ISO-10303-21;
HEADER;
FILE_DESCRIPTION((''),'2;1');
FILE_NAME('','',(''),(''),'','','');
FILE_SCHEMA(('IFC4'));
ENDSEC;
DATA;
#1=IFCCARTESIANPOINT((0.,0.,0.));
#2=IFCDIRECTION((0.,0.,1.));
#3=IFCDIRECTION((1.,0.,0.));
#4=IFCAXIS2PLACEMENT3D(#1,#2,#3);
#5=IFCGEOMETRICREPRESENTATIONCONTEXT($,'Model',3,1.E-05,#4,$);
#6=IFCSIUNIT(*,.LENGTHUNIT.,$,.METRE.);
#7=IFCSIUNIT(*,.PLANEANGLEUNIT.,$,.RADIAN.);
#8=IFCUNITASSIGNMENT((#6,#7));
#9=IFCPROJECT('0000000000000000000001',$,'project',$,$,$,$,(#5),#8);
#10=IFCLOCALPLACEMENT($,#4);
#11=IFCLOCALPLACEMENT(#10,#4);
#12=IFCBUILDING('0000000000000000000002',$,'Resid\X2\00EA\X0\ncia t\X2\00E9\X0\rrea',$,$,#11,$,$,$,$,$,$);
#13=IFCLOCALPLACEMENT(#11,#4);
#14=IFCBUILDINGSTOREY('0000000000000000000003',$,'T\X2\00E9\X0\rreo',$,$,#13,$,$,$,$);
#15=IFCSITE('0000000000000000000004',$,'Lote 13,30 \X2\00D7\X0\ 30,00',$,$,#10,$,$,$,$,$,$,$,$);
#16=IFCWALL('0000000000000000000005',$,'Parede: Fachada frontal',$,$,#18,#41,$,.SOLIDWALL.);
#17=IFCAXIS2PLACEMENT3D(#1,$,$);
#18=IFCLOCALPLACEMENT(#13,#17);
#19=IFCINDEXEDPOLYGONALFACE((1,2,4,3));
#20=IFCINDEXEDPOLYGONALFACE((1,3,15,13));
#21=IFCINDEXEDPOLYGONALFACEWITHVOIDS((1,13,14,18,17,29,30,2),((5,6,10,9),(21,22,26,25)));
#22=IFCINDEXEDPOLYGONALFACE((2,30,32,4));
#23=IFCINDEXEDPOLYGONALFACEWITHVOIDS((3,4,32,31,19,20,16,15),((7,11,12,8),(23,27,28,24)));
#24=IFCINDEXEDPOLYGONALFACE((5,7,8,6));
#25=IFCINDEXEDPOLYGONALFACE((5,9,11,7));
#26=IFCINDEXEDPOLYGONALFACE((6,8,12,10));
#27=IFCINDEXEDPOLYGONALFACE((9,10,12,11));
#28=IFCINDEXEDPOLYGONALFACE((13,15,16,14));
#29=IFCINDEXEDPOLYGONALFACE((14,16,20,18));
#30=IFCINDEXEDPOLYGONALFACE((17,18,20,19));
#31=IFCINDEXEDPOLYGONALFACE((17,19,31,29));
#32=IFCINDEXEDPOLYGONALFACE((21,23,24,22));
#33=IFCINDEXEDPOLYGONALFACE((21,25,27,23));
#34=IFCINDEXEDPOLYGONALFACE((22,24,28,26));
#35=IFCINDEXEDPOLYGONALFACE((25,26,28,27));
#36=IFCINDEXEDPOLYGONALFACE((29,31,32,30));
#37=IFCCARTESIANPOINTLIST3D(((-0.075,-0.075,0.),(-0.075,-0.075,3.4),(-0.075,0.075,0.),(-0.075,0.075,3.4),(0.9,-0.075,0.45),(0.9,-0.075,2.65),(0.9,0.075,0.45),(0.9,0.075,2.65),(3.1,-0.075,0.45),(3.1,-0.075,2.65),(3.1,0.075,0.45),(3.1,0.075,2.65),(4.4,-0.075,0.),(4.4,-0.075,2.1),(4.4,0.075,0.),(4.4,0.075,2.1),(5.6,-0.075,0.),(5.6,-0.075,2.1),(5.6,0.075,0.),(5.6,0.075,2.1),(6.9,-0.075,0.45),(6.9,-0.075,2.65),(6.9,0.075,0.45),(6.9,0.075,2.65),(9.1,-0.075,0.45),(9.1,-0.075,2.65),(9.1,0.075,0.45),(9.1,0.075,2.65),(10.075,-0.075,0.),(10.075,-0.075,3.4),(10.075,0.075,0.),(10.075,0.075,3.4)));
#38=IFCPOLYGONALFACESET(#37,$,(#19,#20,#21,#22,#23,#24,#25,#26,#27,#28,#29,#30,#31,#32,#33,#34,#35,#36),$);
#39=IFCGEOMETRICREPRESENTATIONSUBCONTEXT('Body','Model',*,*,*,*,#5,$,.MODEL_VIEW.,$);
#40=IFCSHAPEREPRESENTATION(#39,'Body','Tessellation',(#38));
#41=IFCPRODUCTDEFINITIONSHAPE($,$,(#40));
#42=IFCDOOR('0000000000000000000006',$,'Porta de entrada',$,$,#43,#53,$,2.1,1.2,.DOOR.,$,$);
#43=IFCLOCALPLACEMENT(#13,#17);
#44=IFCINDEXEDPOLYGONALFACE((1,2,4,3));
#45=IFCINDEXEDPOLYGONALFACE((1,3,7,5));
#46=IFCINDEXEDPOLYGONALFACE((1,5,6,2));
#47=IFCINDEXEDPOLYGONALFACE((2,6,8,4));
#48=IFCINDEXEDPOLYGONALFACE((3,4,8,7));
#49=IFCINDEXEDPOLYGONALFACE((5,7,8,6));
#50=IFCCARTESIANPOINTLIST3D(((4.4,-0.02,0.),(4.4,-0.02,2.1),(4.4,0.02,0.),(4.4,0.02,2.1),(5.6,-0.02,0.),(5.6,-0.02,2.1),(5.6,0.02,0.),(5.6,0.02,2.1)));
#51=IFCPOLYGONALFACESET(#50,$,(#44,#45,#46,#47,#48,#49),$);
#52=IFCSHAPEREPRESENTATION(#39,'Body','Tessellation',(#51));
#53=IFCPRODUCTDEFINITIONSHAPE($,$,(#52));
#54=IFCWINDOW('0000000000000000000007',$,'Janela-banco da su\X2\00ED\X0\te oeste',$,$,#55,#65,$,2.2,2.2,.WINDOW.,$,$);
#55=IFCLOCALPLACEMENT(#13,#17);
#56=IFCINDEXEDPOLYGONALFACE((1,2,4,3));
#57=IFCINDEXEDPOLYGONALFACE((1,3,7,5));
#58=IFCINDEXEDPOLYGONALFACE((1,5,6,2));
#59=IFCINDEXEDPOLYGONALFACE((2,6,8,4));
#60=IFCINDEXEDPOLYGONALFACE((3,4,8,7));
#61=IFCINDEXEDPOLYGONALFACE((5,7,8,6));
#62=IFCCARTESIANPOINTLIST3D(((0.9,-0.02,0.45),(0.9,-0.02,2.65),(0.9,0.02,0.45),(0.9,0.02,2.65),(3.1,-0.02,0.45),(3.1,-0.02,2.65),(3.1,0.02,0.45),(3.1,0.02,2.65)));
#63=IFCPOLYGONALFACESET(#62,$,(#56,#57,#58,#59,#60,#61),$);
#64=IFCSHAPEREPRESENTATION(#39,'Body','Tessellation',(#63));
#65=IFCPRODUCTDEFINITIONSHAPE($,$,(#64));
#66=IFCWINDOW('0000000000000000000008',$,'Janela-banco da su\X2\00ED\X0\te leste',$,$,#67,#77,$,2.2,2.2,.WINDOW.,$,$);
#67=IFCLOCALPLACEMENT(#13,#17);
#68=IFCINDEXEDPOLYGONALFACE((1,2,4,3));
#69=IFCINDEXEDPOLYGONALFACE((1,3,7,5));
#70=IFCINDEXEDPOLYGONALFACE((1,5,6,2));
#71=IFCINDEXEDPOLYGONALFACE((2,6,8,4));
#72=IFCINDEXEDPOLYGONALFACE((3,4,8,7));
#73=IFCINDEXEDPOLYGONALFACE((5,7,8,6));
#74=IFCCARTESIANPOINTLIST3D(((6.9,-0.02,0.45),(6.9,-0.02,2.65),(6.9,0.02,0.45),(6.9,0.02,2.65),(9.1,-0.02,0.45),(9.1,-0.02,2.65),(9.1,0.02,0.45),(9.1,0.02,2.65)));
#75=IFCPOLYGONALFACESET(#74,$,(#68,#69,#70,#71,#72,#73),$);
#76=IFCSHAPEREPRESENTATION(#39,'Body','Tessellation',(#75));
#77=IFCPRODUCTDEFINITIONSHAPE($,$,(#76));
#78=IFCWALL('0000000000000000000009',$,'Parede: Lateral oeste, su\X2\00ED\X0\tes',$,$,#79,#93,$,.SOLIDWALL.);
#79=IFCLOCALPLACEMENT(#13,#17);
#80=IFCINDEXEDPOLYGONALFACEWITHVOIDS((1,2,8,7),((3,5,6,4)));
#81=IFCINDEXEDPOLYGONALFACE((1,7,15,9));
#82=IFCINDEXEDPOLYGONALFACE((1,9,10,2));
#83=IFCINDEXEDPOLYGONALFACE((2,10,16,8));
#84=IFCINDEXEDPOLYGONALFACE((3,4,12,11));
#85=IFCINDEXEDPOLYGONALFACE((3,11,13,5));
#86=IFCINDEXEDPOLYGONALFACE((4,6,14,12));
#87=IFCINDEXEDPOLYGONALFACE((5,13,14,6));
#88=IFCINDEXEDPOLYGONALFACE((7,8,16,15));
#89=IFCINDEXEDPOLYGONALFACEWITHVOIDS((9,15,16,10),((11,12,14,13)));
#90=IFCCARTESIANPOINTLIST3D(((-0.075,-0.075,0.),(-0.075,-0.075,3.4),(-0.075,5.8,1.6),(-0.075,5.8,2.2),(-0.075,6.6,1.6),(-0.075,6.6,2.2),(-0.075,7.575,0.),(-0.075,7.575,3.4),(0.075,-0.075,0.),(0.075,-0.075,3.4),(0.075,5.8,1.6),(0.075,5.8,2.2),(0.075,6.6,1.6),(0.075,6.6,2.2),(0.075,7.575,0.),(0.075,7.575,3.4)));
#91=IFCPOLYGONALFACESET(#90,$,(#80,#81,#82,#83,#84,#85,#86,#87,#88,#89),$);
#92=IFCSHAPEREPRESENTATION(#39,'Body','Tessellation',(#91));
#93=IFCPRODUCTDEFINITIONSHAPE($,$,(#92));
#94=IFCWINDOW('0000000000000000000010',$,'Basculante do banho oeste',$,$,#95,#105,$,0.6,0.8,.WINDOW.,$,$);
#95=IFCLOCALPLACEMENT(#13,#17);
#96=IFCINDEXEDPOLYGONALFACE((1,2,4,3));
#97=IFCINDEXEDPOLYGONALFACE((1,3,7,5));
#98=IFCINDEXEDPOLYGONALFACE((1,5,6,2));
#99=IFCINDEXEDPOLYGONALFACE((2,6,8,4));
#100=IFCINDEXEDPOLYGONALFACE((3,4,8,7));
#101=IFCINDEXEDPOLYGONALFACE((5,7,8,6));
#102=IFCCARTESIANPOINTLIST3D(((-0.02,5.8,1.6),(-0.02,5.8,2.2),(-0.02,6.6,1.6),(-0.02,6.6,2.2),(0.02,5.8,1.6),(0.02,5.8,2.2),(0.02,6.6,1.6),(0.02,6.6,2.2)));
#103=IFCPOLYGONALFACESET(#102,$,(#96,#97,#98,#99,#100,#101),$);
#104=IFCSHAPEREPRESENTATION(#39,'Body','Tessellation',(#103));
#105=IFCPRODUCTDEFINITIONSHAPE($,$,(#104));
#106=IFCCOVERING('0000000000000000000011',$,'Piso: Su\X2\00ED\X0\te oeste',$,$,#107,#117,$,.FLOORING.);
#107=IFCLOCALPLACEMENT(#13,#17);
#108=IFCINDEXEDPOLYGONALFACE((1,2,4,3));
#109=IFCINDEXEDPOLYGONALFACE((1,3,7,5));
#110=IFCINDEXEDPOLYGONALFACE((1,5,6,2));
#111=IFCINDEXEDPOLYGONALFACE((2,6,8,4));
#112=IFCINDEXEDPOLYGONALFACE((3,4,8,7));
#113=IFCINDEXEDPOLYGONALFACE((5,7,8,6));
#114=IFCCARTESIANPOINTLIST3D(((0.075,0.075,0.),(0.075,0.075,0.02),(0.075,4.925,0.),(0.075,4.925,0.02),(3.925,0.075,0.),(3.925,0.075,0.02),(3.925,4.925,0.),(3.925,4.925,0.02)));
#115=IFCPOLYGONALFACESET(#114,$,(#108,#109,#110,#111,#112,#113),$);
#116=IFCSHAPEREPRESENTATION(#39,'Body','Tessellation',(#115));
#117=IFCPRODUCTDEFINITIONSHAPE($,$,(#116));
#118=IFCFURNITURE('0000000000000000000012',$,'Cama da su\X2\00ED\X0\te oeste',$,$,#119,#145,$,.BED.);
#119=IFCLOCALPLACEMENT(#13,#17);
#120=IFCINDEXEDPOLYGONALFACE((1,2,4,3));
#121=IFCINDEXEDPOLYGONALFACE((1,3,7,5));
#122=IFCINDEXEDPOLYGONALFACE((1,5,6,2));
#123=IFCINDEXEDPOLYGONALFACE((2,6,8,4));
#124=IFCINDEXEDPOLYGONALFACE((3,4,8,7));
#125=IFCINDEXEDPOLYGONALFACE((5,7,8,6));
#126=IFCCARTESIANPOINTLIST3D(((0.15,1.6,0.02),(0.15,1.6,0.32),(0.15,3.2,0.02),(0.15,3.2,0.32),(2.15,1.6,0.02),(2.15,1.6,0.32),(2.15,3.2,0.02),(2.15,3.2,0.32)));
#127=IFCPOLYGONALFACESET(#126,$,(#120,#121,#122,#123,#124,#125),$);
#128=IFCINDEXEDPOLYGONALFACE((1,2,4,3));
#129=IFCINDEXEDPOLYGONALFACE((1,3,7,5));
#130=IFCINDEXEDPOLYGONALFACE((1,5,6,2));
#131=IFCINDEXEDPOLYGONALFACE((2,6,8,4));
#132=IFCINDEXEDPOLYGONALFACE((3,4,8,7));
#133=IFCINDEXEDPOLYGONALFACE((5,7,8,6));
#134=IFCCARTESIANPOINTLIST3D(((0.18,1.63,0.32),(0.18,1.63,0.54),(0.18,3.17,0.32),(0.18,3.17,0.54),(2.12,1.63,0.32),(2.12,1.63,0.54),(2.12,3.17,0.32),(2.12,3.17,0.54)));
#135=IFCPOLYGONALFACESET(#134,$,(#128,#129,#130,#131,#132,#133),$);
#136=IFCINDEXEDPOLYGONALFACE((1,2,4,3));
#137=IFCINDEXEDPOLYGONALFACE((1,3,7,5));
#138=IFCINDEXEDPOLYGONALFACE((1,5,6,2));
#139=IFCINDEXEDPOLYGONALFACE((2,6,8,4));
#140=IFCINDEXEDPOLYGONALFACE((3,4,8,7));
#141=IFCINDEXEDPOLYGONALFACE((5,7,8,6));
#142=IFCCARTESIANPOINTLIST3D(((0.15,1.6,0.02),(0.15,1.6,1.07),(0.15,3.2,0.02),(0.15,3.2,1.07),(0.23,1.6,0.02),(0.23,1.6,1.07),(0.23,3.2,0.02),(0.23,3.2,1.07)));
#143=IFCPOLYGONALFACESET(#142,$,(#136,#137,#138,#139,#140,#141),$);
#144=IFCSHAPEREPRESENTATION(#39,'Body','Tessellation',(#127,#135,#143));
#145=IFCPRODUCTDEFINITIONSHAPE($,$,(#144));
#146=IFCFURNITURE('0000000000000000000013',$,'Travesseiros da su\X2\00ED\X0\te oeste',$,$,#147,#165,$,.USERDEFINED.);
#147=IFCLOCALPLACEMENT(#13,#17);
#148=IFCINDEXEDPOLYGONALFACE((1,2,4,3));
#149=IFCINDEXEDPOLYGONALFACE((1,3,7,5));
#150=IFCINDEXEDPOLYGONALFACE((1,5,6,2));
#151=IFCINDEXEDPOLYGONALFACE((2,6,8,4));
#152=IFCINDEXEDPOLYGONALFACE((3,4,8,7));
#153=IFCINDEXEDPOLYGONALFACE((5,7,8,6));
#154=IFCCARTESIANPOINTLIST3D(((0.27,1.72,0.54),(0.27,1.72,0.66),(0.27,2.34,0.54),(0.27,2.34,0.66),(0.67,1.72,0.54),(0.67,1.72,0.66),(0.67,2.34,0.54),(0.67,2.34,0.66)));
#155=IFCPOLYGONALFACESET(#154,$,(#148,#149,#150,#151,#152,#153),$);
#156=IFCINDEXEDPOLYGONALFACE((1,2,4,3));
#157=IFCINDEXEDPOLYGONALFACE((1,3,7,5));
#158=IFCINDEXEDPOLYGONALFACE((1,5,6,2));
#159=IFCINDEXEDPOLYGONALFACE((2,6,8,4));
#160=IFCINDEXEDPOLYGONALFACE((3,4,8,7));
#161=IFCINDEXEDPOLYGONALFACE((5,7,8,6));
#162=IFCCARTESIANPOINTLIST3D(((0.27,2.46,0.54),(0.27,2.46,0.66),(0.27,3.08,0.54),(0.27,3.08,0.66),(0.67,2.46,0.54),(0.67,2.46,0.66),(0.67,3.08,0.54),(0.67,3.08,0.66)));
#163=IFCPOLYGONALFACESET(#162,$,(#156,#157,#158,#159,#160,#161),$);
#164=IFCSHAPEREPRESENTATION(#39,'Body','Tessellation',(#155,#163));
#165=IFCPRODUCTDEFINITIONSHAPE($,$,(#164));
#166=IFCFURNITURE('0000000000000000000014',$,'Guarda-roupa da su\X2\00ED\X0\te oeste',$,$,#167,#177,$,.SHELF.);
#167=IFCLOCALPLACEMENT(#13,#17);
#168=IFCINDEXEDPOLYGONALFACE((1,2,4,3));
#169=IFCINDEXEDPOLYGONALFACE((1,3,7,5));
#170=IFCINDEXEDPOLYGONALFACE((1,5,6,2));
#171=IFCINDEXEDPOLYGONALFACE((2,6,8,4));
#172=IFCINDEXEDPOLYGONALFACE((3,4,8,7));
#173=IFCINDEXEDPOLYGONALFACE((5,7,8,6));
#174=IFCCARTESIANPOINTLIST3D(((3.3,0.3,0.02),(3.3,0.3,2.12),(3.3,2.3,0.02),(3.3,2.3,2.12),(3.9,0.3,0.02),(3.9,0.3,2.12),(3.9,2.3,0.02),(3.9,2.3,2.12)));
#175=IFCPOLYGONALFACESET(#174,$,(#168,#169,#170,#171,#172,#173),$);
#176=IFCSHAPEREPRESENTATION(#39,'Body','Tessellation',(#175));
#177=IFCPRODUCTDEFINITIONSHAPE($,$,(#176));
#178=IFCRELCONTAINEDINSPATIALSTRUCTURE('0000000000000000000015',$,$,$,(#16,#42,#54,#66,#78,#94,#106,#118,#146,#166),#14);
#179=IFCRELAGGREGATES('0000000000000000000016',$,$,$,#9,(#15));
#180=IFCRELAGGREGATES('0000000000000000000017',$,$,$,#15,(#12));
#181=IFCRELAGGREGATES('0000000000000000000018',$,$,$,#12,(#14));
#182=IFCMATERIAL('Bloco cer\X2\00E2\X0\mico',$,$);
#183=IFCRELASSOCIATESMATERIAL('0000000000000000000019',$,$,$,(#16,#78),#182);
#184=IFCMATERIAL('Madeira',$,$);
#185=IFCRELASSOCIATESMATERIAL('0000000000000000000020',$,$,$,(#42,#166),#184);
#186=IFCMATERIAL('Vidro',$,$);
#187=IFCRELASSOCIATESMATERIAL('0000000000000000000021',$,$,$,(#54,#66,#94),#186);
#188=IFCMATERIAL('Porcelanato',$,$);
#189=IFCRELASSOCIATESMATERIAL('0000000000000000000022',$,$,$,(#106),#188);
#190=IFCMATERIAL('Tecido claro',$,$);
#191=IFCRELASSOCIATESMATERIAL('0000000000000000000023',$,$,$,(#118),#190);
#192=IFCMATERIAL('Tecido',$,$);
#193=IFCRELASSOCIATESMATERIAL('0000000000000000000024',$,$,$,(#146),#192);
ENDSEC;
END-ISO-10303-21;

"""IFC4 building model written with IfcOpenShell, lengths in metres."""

from ifc_helpers import new_model, si_unit, frame, origin_with_axes, place, context, subcontext, project, spatial, line, indexed_curve, outline, extrude, material, element, fill, save


model = new_model("IFC4")

# Units and contexts
model_context = context("Model", 3, precision=1e-05, world=origin_with_axes())
body_context = subcontext(model_context, "Body", "Model", "MODEL_VIEW")
ifc_project = project(units=[si_unit("LENGTHUNIT", "METRE"), si_unit("PLANEANGLEUNIT", "RADIAN")], contexts=[model_context])

# Site, building, storey
site_placement = place(None, origin_with_axes())
site = spatial("IfcSite", under=ifc_project, at=site_placement, Name="Lote 13,30 × 30,00")
building_placement = place(site_placement, origin_with_axes())
building = spatial("IfcBuilding", under=site, at=building_placement, Name="Residência térrea")
storey_placement = place(building_placement, origin_with_axes())
storey = spatial("IfcBuildingStorey", under=building, at=storey_placement, Name="Térreo")

# Shared definitions
ifc_material_1 = material(Name="Concreto armado")

# Wall, openings, door, windows
ifc_material_2 = material(Name="Bloco cerâmico")
wall_1_placement = place(storey_placement, frame((-0.075, -0.075, 0.0), z_axis=(0.0, 0.0, 1.0), x_axis=(1.0, 0.0, 0.0)))
wall_1 = element("IfcWall", 1, at=wall_1_placement, inside=storey, material=ifc_material_2, Name="Parede: Fachada frontal", PredefinedType="SOLIDWALL", context=body_context, shape_type="SweptSolid", body=[
    extrude(outline(indexed_curve([(0.0, 0.0), (10.15, 0.0), (10.15, 0.15), (0.0, 0.15)], segments=[line(1, 2, 3, 4, 1)])), origin_with_axes(), (0.0, 0.0, 1.0), 3.4),
])
opening_1_placement = place(wall_1_placement, frame((4.475, -0.05, 0.0), z_axis=(0.0, 0.0, 1.0), x_axis=(1.0, 0.0, 0.0)))
opening_1 = element("IfcOpeningElement", 2, at=opening_1_placement, cuts=wall_1, material=ifc_material_1, PredefinedType="OPENING", context=body_context, shape_type="SweptSolid", body=[
    extrude(outline(indexed_curve([(0.0, 0.0), (1.2, 0.0), (1.2, 0.25), (0.0, 0.25)], segments=[line(1, 2, 3, 4, 1)])), origin_with_axes(), (0.0, 0.0, 1.0), 2.1),
])
opening_2_placement = place(wall_1_placement, frame((0.975, -0.05, 0.45), z_axis=(0.0, 0.0, 1.0), x_axis=(1.0, 0.0, 0.0)))
opening_2 = element("IfcOpeningElement", 3, at=opening_2_placement, cuts=wall_1, material=ifc_material_1, PredefinedType="OPENING", context=body_context, shape_type="SweptSolid", body=[
    extrude(outline(indexed_curve([(0.0, 0.0), (2.2, 0.0), (2.2, 0.25), (0.0, 0.25)], segments=[line(1, 2, 3, 4, 1)])), origin_with_axes(), (0.0, 0.0, 1.0), 2.2),
])
opening_3_placement = place(wall_1_placement, frame((6.975, -0.05, 0.45), z_axis=(0.0, 0.0, 1.0), x_axis=(1.0, 0.0, 0.0)))
opening_3 = element("IfcOpeningElement", 4, at=opening_3_placement, cuts=wall_1, material=ifc_material_1, PredefinedType="OPENING", context=body_context, shape_type="SweptSolid", body=[
    extrude(outline(indexed_curve([(0.0, 0.0), (2.2, 0.0), (2.2, 0.25), (0.0, 0.25)], segments=[line(1, 2, 3, 4, 1)])), origin_with_axes(), (0.0, 0.0, 1.0), 2.2),
])
ifc_material_3 = material(Name="Madeira")
door_placement = place(storey_placement, frame((4.4, -0.02, 0.0), z_axis=(0.0, 0.0, 1.0), x_axis=(1.0, 0.0, 0.0)))
door = element("IfcDoor", 5, at=door_placement, inside=storey, material=ifc_material_3, Name="Porta de entrada", OverallHeight=2.1, OverallWidth=1.2, PredefinedType="DOOR", context=body_context, shape_type="SweptSolid", body=[
    extrude(outline(indexed_curve([(0.0, 0.0), (1.2, 0.0), (1.2, 0.04), (0.0, 0.04)], segments=[line(1, 2, 3, 4, 1)])), origin_with_axes(), (0.0, 0.0, 1.0), 2.1),
])
fill(opening_1, door)
ifc_material_4 = material(Name="Vidro")
window_1_placement = place(storey_placement, frame((0.9, -0.02, 0.45), z_axis=(0.0, 0.0, 1.0), x_axis=(1.0, 0.0, 0.0)))
window_1 = element("IfcWindow", 6, at=window_1_placement, inside=storey, material=ifc_material_4, Name="Janela-banco da suíte oeste", OverallHeight=2.2, OverallWidth=2.2, PredefinedType="WINDOW", context=body_context, shape_type="SweptSolid", body=[
    extrude(outline(indexed_curve([(0.0, 0.0), (2.2, 0.0), (2.2, 0.04), (0.0, 0.04)], segments=[line(1, 2, 3, 4, 1)])), origin_with_axes(), (0.0, 0.0, 1.0), 2.2),
])
fill(opening_2, window_1)
window_2_placement = place(storey_placement, frame((6.9, -0.02, 0.45), z_axis=(0.0, 0.0, 1.0), x_axis=(1.0, 0.0, 0.0)))
window_2 = element("IfcWindow", 7, at=window_2_placement, inside=storey, material=ifc_material_4, Name="Janela-banco da suíte leste", OverallHeight=2.2, OverallWidth=2.2, PredefinedType="WINDOW", context=body_context, shape_type="SweptSolid", body=[
    extrude(outline(indexed_curve([(0.0, 0.0), (2.2, 0.0), (2.2, 0.04), (0.0, 0.04)], segments=[line(1, 2, 3, 4, 1)])), origin_with_axes(), (0.0, 0.0, 1.0), 2.2),
])
fill(opening_3, window_2)

# Wall, opening, window
wall_2_placement = place(storey_placement, frame((-0.075, -0.075, 0.0), z_axis=(0.0, 0.0, 1.0), x_axis=(1.0, 0.0, 0.0)))
wall_2 = element("IfcWall", 8, at=wall_2_placement, inside=storey, material=ifc_material_2, Name="Parede: Lateral oeste, suítes", PredefinedType="SOLIDWALL", context=body_context, shape_type="SweptSolid", body=[
    extrude(outline(indexed_curve([(0.0, 0.0), (0.15, 0.0), (0.15, 7.65), (0.0, 7.65)], segments=[line(1, 2, 3, 4, 1)])), origin_with_axes(), (0.0, 0.0, 1.0), 3.4),
])
opening_4_placement = place(wall_2_placement, frame((-0.05, 5.875, 1.6), z_axis=(0.0, 0.0, 1.0), x_axis=(1.0, 0.0, 0.0)))
opening_4 = element("IfcOpeningElement", 9, at=opening_4_placement, cuts=wall_2, material=ifc_material_1, PredefinedType="OPENING", context=body_context, shape_type="SweptSolid", body=[
    extrude(outline(indexed_curve([(0.0, 0.0), (0.25, 0.0), (0.25, 0.8), (0.0, 0.8)], segments=[line(1, 2, 3, 4, 1)])), origin_with_axes(), (0.0, 0.0, 1.0), 0.6),
])
window_3_placement = place(storey_placement, frame((-0.02, 5.8, 1.6), z_axis=(0.0, 0.0, 1.0), x_axis=(1.0, 0.0, 0.0)))
window_3 = element("IfcWindow", 10, at=window_3_placement, inside=storey, material=ifc_material_4, Name="Basculante do banho oeste", OverallHeight=0.6, OverallWidth=0.8, PredefinedType="WINDOW", context=body_context, shape_type="SweptSolid", body=[
    extrude(outline(indexed_curve([(0.0, 0.0), (0.04, 0.0), (0.04, 0.8), (0.0, 0.8)], segments=[line(1, 2, 3, 4, 1)])), origin_with_axes(), (0.0, 0.0, 1.0), 0.6),
])
fill(opening_4, window_3)

# Covering
ifc_material_5 = material(Name="Porcelanato")
covering_placement = place(storey_placement, frame((0.075, 0.075, 0.0), z_axis=(0.0, 0.0, 1.0), x_axis=(1.0, 0.0, 0.0)))
element("IfcCovering", 11, at=covering_placement, inside=storey, material=ifc_material_5, Name="Piso: Suíte oeste", PredefinedType="FLOORING", context=body_context, shape_type="SweptSolid", body=[
    extrude(outline(indexed_curve([(0.0, 0.0), (3.85, 0.0), (3.85, 4.85), (0.0, 4.85)], segments=[line(1, 2, 3, 4, 1)])), origin_with_axes(), (0.0, 0.0, 1.0), 0.02),
])

# Furniture
ifc_material_6 = material(Name="Tecido claro")
furniture_1_placement = place(storey_placement, frame((0.15, 1.6, 0.02), z_axis=(0.0, 0.0, 1.0), x_axis=(1.0, 0.0, 0.0)))
element("IfcFurniture", 12, at=furniture_1_placement, inside=storey, material=ifc_material_6, Name="Cama da suíte oeste", PredefinedType="BED", context=body_context, shape_type="SweptSolid", body=[
    extrude(outline(indexed_curve([(0.0, 0.0), (2.0, 0.0), (2.0, 1.6), (0.0, 1.6)], segments=[line(1, 2, 3, 4, 1)])), origin_with_axes(), (0.0, 0.0, 1.0), 0.3),
    extrude(outline(indexed_curve([(0.03, 0.03), (1.97, 0.03), (1.97, 1.57), (0.03, 1.57)], segments=[line(1, 2, 3, 4, 1)])), frame((0.0, 0.0, 0.3), z_axis=(0.0, 0.0, 1.0), x_axis=(1.0, 0.0, 0.0)), (0.0, 0.0, 1.0), 0.22),
    extrude(outline(indexed_curve([(0.0, 0.0), (0.08, 0.0), (0.08, 1.6), (0.0, 1.6)], segments=[line(1, 2, 3, 4, 1)])), origin_with_axes(), (0.0, 0.0, 1.0), 1.05),
])
ifc_material_7 = material(Name="Tecido")
furniture_2_placement = place(storey_placement, frame((0.27, 1.72, 0.54), z_axis=(0.0, 0.0, 1.0), x_axis=(1.0, 0.0, 0.0)))
element("IfcFurniture", 13, at=furniture_2_placement, inside=storey, material=ifc_material_7, Name="Travesseiros da suíte oeste", PredefinedType="USERDEFINED", context=body_context, shape_type="SweptSolid", body=[
    extrude(outline(indexed_curve([(0.0, 0.0), (0.4, 0.0), (0.4, 0.62), (0.0, 0.62)], segments=[line(1, 2, 3, 4, 1)])), origin_with_axes(), (0.0, 0.0, 1.0), 0.12),
    extrude(outline(indexed_curve([(0.0, 0.74), (0.4, 0.74), (0.4, 1.36), (0.0, 1.36)], segments=[line(1, 2, 3, 4, 1)])), origin_with_axes(), (0.0, 0.0, 1.0), 0.12),
])
furniture_3_placement = place(storey_placement, frame((3.3, 0.3, 0.02), z_axis=(0.0, 0.0, 1.0), x_axis=(1.0, 0.0, 0.0)))
element("IfcFurniture", 14, at=furniture_3_placement, inside=storey, material=ifc_material_3, Name="Guarda-roupa da suíte oeste", PredefinedType="SHELF", context=body_context, shape_type="SweptSolid", body=[
    extrude(outline(indexed_curve([(0.0, 0.0), (0.6, 0.0), (0.6, 2.0), (0.0, 2.0)], segments=[line(1, 2, 3, 4, 1)])), origin_with_axes(), (0.0, 0.0, 1.0), 2.1),
])

save(model, "model.ifc")
